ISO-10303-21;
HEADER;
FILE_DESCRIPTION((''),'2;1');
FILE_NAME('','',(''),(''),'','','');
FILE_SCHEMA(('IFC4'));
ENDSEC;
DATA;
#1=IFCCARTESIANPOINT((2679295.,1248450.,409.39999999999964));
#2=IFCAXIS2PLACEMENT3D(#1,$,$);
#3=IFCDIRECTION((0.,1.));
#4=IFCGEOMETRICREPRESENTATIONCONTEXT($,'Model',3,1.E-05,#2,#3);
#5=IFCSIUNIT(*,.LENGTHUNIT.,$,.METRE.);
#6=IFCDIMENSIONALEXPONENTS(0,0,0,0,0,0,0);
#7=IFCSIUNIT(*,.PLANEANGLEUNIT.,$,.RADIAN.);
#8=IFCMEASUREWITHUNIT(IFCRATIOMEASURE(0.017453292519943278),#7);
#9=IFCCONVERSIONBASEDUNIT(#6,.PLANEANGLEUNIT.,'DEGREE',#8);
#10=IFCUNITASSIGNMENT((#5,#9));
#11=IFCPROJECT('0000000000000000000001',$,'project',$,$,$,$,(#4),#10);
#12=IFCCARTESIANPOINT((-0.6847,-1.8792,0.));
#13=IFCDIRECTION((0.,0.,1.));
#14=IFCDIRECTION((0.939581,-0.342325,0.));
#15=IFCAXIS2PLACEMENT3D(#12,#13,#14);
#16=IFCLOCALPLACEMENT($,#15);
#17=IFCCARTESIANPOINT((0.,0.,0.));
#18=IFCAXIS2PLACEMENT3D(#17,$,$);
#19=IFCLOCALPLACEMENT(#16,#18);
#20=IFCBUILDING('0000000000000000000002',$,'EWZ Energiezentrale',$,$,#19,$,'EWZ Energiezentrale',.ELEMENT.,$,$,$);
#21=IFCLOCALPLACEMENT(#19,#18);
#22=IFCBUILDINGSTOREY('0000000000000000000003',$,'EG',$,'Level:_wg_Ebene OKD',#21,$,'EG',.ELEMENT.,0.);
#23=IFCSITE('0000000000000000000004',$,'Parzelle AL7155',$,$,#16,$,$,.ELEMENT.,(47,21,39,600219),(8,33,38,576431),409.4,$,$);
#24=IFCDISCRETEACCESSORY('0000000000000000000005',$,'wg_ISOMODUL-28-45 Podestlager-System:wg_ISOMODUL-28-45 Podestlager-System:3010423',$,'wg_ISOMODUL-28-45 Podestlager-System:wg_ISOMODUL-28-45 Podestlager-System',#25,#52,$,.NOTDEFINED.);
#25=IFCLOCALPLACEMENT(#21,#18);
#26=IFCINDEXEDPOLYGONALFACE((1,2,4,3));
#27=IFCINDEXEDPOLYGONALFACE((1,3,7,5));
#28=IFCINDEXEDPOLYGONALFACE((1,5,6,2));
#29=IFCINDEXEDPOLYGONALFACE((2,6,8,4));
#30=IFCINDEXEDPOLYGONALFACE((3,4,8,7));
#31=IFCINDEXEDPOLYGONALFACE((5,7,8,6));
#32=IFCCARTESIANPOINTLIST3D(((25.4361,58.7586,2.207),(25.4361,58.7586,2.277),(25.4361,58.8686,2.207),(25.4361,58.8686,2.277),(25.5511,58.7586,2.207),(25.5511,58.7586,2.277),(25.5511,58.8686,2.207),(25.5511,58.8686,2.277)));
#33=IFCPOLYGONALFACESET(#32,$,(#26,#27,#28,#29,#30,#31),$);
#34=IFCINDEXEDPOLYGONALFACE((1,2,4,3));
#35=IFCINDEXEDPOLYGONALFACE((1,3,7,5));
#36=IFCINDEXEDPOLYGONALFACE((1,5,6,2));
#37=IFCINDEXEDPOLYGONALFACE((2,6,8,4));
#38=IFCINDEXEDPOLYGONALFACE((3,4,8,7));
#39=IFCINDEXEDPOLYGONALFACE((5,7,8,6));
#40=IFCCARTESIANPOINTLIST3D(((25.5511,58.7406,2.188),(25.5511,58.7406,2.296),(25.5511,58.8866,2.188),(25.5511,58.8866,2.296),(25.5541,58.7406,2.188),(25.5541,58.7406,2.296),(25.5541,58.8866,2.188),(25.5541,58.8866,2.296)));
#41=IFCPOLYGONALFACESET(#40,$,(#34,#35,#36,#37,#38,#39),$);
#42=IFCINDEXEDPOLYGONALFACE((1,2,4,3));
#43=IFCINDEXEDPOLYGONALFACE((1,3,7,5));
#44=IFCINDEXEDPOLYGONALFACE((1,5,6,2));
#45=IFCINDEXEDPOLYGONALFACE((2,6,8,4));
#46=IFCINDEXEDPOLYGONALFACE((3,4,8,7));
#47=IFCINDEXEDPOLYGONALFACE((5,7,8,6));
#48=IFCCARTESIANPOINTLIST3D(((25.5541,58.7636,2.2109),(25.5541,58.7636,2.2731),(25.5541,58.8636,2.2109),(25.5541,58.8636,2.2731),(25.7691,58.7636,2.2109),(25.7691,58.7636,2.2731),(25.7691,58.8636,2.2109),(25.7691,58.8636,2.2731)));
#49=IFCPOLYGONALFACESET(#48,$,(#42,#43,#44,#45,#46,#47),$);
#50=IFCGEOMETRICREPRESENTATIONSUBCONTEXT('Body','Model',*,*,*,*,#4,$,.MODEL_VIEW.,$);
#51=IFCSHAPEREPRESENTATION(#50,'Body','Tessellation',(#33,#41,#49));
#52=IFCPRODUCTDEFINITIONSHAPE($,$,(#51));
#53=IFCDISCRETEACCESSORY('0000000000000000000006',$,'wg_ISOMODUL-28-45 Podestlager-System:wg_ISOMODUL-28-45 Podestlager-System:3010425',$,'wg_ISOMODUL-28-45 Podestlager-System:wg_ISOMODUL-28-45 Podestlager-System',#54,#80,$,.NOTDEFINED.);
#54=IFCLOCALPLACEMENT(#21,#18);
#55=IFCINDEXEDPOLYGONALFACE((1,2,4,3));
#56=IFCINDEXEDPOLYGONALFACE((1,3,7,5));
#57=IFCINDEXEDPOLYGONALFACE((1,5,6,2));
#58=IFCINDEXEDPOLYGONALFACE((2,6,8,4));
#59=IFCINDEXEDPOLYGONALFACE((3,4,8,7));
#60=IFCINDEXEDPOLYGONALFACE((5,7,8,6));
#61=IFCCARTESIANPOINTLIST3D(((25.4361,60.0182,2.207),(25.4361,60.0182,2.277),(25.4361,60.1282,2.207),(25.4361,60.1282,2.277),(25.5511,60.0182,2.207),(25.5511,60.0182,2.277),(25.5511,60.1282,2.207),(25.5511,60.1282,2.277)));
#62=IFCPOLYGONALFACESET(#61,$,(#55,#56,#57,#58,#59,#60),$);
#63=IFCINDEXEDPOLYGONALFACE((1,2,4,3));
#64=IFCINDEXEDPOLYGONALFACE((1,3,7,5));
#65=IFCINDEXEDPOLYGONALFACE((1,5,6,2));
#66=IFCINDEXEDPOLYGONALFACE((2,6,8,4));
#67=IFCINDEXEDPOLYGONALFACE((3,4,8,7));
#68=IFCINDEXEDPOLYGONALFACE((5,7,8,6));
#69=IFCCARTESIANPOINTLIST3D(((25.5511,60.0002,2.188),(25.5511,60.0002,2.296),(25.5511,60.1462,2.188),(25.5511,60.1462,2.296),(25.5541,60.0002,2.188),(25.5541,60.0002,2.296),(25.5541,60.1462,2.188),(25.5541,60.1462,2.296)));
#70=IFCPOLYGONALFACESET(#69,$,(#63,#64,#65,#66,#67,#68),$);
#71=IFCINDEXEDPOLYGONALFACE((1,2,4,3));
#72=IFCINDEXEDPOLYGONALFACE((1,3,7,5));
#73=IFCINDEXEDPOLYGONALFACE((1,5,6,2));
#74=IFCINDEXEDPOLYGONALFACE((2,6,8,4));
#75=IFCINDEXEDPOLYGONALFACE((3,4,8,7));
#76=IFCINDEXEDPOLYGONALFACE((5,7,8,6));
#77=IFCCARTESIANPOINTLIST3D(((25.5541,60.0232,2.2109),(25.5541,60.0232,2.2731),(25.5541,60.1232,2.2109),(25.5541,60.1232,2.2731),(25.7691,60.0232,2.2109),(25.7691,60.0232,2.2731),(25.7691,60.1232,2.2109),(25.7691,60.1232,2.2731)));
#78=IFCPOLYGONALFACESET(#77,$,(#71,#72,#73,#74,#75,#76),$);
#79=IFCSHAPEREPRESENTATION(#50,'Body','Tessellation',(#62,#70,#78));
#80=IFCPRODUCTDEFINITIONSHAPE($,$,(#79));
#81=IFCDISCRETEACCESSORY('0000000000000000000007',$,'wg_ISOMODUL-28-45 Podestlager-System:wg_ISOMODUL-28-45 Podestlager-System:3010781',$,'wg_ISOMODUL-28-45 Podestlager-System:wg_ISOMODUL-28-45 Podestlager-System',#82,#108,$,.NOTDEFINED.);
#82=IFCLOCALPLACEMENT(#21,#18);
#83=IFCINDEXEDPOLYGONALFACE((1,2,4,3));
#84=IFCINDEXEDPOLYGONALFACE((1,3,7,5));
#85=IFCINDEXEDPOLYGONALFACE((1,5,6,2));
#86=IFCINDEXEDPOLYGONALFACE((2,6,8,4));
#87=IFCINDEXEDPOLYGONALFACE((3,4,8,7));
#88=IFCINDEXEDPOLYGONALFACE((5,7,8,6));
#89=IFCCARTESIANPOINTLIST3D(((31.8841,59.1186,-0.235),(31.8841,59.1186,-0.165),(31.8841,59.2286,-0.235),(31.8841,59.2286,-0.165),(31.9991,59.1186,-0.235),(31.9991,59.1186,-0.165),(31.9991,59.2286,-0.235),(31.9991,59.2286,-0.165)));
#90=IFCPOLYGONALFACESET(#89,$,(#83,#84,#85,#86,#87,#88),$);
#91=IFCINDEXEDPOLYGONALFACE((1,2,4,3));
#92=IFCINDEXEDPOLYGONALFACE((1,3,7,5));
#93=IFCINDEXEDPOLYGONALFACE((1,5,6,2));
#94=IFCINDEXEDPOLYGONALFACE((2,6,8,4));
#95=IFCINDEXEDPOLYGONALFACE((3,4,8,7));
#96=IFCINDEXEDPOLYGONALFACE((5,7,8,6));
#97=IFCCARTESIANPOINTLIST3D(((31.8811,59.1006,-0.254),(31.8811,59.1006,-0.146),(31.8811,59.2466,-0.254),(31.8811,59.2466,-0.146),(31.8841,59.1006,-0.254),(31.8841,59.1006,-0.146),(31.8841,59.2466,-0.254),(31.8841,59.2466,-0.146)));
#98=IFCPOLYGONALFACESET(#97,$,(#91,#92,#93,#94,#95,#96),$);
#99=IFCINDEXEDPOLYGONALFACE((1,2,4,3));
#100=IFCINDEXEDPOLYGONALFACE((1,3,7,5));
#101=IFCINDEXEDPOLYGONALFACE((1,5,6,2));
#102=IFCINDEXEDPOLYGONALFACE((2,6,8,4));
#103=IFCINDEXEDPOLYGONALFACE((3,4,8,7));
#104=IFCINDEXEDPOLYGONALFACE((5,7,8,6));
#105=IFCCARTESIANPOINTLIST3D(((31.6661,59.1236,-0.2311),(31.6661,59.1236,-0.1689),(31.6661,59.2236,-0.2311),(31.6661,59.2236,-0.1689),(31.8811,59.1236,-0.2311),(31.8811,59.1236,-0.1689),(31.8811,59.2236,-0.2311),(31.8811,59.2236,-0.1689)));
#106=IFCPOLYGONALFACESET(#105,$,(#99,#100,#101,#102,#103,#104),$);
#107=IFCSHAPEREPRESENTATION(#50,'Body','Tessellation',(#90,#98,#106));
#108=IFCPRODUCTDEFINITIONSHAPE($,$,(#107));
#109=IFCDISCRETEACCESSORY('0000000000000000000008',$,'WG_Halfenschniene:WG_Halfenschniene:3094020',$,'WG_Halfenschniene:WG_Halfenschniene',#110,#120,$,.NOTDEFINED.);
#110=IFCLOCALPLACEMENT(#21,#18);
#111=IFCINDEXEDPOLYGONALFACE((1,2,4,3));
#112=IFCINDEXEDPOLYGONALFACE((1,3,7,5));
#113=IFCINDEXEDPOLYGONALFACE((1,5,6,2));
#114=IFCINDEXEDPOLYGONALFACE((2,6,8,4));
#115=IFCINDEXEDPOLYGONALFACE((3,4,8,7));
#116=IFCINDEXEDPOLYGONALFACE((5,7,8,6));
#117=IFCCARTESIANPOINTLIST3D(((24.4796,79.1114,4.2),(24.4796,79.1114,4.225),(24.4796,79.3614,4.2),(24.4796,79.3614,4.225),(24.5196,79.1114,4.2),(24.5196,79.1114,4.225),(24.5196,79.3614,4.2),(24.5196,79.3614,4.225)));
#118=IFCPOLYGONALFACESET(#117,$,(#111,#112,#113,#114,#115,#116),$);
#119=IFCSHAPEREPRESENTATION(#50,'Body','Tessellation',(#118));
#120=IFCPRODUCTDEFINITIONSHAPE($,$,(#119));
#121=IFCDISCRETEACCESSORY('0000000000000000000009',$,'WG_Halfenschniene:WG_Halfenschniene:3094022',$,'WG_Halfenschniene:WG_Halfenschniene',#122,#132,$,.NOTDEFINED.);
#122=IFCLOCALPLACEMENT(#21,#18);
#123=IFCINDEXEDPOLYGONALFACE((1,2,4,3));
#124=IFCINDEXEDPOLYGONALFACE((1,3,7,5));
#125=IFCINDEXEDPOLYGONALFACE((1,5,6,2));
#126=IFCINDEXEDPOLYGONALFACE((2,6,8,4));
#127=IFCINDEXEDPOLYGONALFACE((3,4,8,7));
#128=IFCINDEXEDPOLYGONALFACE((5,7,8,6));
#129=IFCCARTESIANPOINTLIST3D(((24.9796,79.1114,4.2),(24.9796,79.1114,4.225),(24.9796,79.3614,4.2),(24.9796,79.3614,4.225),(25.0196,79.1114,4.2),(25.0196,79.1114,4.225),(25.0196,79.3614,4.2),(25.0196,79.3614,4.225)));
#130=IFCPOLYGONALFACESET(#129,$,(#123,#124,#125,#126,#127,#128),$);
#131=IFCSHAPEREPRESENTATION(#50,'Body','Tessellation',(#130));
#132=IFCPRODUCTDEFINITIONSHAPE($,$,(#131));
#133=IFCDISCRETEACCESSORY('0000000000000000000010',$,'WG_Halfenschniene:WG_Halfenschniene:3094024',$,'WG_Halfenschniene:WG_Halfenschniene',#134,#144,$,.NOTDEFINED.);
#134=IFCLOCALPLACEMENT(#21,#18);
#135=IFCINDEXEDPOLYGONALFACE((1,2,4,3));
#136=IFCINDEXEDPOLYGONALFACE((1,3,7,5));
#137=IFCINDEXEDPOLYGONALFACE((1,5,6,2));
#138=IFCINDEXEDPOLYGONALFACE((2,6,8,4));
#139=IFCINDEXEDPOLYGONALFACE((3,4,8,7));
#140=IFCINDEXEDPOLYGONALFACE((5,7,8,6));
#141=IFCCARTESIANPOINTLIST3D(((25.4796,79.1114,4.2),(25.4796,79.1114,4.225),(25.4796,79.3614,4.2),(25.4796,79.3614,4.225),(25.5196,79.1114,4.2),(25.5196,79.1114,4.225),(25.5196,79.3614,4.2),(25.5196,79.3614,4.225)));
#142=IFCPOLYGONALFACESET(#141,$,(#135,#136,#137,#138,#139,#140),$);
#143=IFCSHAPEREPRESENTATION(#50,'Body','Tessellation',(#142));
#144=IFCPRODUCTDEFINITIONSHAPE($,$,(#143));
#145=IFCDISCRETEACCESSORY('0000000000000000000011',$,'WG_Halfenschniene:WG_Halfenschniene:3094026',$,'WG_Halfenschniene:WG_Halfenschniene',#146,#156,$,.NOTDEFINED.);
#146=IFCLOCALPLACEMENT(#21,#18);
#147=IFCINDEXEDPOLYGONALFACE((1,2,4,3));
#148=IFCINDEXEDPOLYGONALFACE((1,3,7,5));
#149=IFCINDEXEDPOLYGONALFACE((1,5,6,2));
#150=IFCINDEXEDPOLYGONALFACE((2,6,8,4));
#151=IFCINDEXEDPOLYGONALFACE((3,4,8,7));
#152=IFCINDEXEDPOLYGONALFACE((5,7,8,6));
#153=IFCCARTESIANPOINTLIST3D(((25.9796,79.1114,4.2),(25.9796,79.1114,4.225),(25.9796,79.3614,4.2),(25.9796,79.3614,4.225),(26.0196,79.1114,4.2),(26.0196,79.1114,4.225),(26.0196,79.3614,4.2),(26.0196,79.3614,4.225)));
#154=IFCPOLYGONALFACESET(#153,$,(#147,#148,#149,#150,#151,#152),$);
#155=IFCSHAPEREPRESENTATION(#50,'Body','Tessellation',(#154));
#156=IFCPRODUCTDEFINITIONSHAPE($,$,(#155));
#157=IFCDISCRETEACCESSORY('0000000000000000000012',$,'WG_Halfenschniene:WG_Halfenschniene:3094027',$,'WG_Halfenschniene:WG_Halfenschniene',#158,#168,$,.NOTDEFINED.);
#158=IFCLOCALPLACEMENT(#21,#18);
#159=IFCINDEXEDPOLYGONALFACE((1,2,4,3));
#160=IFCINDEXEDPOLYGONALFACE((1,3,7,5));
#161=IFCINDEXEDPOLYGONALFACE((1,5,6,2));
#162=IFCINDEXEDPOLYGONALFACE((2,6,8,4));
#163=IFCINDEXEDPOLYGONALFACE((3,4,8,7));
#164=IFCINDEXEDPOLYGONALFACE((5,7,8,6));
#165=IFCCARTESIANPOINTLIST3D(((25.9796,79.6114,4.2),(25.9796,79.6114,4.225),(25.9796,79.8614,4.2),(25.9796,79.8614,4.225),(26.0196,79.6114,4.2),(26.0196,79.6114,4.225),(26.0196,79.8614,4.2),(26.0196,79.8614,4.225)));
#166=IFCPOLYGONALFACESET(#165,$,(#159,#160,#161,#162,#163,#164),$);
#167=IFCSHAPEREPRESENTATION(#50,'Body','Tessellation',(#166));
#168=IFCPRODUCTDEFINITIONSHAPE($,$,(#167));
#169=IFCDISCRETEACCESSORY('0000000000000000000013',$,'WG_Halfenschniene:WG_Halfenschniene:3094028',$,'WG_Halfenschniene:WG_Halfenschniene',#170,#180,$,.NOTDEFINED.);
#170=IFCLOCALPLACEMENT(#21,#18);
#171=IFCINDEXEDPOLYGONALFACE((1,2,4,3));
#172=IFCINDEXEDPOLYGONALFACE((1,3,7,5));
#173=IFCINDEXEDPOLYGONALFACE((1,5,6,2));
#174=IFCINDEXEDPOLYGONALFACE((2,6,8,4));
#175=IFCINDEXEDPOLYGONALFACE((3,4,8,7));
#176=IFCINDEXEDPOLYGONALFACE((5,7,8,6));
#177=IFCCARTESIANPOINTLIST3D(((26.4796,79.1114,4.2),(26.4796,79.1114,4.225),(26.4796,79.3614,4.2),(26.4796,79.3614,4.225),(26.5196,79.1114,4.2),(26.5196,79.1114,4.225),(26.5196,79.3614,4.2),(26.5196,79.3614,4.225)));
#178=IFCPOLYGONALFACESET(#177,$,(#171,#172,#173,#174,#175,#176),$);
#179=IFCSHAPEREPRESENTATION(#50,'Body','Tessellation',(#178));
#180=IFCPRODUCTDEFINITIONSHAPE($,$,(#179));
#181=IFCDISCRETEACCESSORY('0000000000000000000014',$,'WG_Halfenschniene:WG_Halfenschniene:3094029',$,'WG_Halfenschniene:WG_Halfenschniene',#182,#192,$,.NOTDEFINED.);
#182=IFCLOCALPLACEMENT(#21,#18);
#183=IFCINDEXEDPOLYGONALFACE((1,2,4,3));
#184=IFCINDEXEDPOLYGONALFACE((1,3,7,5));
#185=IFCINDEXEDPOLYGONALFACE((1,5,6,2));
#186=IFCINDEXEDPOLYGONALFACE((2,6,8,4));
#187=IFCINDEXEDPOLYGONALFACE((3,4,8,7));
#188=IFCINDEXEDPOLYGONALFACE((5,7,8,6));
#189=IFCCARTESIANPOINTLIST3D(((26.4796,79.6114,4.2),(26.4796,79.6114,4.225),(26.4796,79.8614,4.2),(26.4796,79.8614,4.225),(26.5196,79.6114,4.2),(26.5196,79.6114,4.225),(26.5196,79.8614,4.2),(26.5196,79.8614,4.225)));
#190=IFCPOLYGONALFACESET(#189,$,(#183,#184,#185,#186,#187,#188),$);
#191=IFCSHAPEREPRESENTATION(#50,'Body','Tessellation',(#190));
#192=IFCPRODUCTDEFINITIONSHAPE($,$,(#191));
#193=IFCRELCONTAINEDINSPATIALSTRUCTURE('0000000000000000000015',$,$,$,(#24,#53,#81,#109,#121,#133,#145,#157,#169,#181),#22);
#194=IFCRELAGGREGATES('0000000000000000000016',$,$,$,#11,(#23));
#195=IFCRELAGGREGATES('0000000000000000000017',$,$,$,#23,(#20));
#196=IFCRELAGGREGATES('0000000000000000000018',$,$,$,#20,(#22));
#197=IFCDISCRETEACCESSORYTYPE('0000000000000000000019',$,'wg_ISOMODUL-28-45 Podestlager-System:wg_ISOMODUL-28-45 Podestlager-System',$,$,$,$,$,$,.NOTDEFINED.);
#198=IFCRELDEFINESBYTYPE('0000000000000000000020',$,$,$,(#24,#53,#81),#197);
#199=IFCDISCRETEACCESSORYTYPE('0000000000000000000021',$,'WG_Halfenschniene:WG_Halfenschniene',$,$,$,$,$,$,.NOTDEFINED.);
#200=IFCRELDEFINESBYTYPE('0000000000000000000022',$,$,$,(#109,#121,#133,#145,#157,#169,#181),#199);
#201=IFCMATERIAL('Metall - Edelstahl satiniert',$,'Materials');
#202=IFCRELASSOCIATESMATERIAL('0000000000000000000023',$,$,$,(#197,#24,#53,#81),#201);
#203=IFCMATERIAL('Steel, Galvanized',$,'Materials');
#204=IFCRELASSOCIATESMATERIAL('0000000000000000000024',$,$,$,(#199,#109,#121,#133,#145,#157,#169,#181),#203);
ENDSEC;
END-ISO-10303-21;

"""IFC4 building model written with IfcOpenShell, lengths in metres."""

from ifc_helpers import new_model, entity, si_unit, converted_unit, direction, frame, origin, place, context, subcontext, project, spatial, indexed_curve, outline, extrude, source, transform, mapped, material, type_object, element, save


model = new_model("IFC4")

# Units and contexts
model_context = context("Model", 3, precision=1e-05, world=frame((2679295.0, 1248450.0, 409.39999999999964)), true_north=direction((0.0, 1.0)))
body_context = subcontext(model_context, "Body", "Model", "MODEL_VIEW")
ifc_project = project(units=[si_unit("LENGTHUNIT", "METRE"), converted_unit("PLANEANGLEUNIT", "DEGREE", entity("IfcRatioMeasure", 0.017453292519943278), si_unit("PLANEANGLEUNIT", "RADIAN"), dimensions=[0, 0, 0, 0, 0, 0, 0])], contexts=[model_context])

# Site, building, storey
site_placement = place(None, frame((-0.6847, -1.8792, 0.0), z_axis=(0.0, 0.0, 1.0), x_axis=(0.939581, -0.342325, 0.0)))
site = spatial("IfcSite", under=ifc_project, at=site_placement, Name="Parzelle AL7155", CompositionType="ELEMENT", RefLatitude=(47, 21, 39, 600219), RefLongitude=(8, 33, 38, 576431), RefElevation=409.4)
building_placement = place(site_placement, origin())
building = spatial("IfcBuilding", under=site, at=building_placement, Name="EWZ Energiezentrale", LongName="EWZ Energiezentrale", CompositionType="ELEMENT")
storey_placement = place(building_placement, origin())
storey = spatial("IfcBuildingStorey", under=building, at=storey_placement, Name="EG", ObjectType="Level:_wg_Ebene OKD", LongName="EG", CompositionType="ELEMENT", Elevation=0.0)

# Discrete accessories
ifc_material_1 = material(Name="Metall - Edelstahl satiniert", Category="Materials")
discrete_accessory_type_1 = type_object("IfcDiscreteAccessoryType", Name="wg_ISOMODUL-28-45 Podestlager-System:wg_ISOMODUL-28-45 Podestlager-System", PredefinedType="NOTDEFINED", material=ifc_material_1)
shared_shape_1 = source(origin(), body_context, "Body", "SweptSolid", [
    extrude(outline(indexed_curve([(-0.0575, -0.055), (0.0575, -0.055), (0.0575, 0.055), (-0.0575, 0.055), (-0.0575, -0.055)], self_intersect=False)), frame((0.0, 0.0575, 0.0), z_axis=(0.0, 0.0, 1.0), x_axis=(0.0, 1.0, 0.0)), (0.0, 0.0, 1.0), 0.07),
    extrude(outline(indexed_curve([(-0.0015, -0.073), (0.0015, -0.073), (0.0015, 0.073), (-0.0015, 0.073), (-0.0015, -0.073)], self_intersect=False)), frame((0.0, -0.0015, -0.019), z_axis=(0.0, 0.0, 1.0), x_axis=(0.0, 1.0, 0.0)), (0.0, 0.0, 1.0), 0.108),
    extrude(outline(indexed_curve([(-0.1075, -0.05), (0.1075, -0.05), (0.1075, 0.05), (-0.1075, 0.05), (-0.1075, -0.05)], self_intersect=False)), frame((0.0, -0.1105, 0.0039), z_axis=(0.0, 0.0, 1.0), x_axis=(0.0, 1.0, 0.0)), (0.0, 0.0, 1.0), 0.0621),
])
for number, where, z_axis, x_axis, name in (
    (1, (25.5511, 58.8136, 2.207), (0.0, 0.0, 1.0), (0.0, 1.0, 0.0), "wg_ISOMODUL-28-45 Podestlager-System:wg_ISOMODUL-28-45 Podestlager-System:3010423"),
    (2, (25.5511, 60.0732, 2.207), (0.0, 0.0, 1.0), (0.0, 1.0, 0.0), "wg_ISOMODUL-28-45 Podestlager-System:wg_ISOMODUL-28-45 Podestlager-System:3010425"),
    (3, (31.8841, 59.1736, -0.235), (0.0, 0.0, 1.0), (0.0, -1.0, 0.0), "wg_ISOMODUL-28-45 Podestlager-System:wg_ISOMODUL-28-45 Podestlager-System:3010781"),
):
    element("IfcDiscreteAccessory", number, at=place(storey_placement, frame(where, z_axis=z_axis, x_axis=x_axis)), inside=storey, type_object=discrete_accessory_type_1, material=ifc_material_1, Name=name, ObjectType="wg_ISOMODUL-28-45 Podestlager-System:wg_ISOMODUL-28-45 Podestlager-System", PredefinedType="NOTDEFINED", context=body_context, shape_type="MappedRepresentation", body=[
        mapped(shared_shape_1, transform((0.0, 0.0, 0.0), scale=1.0)),
    ])
ifc_material_2 = material(Name="Steel, Galvanized", Category="Materials")
discrete_accessory_type_2 = type_object("IfcDiscreteAccessoryType", Name="WG_Halfenschniene:WG_Halfenschniene", PredefinedType="NOTDEFINED", material=ifc_material_2)
shared_shape_2 = source(origin(), body_context, "Body", "SweptSolid", [
    extrude(outline(indexed_curve([(-0.125, -0.02), (0.125, -0.02), (0.125, 0.02), (-0.125, 0.02), (-0.125, -0.02)], self_intersect=False)), frame((0.125, 0.0, -0.0125)), (0.0, 0.0, 1.0), 0.025),
])
for number, where, z_axis, x_axis, name in (
    (4, (24.4996, 79.1114, 4.2125), (0.0, 0.0, -1.0), (0.0, 1.0, 0.0), "WG_Halfenschniene:WG_Halfenschniene:3094020"),
    (5, (24.9996, 79.1114, 4.2125), (0.0, 0.0, -1.0), (0.0, 1.0, 0.0), "WG_Halfenschniene:WG_Halfenschniene:3094022"),
    (6, (25.4996, 79.1114, 4.2125), (0.0, 0.0, -1.0), (0.0, 1.0, 0.0), "WG_Halfenschniene:WG_Halfenschniene:3094024"),
    (7, (25.9996, 79.1114, 4.2125), (0.0, 0.0, -1.0), (0.0, 1.0, 0.0), "WG_Halfenschniene:WG_Halfenschniene:3094026"),
    (8, (25.9996, 79.6114, 4.2125), (0.0, 0.0, -1.0), (0.0, 1.0, 0.0), "WG_Halfenschniene:WG_Halfenschniene:3094027"),
    (9, (26.4996, 79.1114, 4.2125), (0.0, 0.0, -1.0), (0.0, 1.0, 0.0), "WG_Halfenschniene:WG_Halfenschniene:3094028"),
    (10, (26.4996, 79.6114, 4.2125), (0.0, 0.0, -1.0), (0.0, 1.0, 0.0), "WG_Halfenschniene:WG_Halfenschniene:3094029"),
):
    element("IfcDiscreteAccessory", number, at=place(storey_placement, frame(where, z_axis=z_axis, x_axis=x_axis)), inside=storey, type_object=discrete_accessory_type_2, material=ifc_material_2, Name=name, ObjectType="WG_Halfenschniene:WG_Halfenschniene", PredefinedType="NOTDEFINED", context=body_context, shape_type="MappedRepresentation", body=[
        mapped(shared_shape_2, transform((0.0, 0.0, 0.0), scale=1.0)),
    ])

save(model, "model.ifc")
